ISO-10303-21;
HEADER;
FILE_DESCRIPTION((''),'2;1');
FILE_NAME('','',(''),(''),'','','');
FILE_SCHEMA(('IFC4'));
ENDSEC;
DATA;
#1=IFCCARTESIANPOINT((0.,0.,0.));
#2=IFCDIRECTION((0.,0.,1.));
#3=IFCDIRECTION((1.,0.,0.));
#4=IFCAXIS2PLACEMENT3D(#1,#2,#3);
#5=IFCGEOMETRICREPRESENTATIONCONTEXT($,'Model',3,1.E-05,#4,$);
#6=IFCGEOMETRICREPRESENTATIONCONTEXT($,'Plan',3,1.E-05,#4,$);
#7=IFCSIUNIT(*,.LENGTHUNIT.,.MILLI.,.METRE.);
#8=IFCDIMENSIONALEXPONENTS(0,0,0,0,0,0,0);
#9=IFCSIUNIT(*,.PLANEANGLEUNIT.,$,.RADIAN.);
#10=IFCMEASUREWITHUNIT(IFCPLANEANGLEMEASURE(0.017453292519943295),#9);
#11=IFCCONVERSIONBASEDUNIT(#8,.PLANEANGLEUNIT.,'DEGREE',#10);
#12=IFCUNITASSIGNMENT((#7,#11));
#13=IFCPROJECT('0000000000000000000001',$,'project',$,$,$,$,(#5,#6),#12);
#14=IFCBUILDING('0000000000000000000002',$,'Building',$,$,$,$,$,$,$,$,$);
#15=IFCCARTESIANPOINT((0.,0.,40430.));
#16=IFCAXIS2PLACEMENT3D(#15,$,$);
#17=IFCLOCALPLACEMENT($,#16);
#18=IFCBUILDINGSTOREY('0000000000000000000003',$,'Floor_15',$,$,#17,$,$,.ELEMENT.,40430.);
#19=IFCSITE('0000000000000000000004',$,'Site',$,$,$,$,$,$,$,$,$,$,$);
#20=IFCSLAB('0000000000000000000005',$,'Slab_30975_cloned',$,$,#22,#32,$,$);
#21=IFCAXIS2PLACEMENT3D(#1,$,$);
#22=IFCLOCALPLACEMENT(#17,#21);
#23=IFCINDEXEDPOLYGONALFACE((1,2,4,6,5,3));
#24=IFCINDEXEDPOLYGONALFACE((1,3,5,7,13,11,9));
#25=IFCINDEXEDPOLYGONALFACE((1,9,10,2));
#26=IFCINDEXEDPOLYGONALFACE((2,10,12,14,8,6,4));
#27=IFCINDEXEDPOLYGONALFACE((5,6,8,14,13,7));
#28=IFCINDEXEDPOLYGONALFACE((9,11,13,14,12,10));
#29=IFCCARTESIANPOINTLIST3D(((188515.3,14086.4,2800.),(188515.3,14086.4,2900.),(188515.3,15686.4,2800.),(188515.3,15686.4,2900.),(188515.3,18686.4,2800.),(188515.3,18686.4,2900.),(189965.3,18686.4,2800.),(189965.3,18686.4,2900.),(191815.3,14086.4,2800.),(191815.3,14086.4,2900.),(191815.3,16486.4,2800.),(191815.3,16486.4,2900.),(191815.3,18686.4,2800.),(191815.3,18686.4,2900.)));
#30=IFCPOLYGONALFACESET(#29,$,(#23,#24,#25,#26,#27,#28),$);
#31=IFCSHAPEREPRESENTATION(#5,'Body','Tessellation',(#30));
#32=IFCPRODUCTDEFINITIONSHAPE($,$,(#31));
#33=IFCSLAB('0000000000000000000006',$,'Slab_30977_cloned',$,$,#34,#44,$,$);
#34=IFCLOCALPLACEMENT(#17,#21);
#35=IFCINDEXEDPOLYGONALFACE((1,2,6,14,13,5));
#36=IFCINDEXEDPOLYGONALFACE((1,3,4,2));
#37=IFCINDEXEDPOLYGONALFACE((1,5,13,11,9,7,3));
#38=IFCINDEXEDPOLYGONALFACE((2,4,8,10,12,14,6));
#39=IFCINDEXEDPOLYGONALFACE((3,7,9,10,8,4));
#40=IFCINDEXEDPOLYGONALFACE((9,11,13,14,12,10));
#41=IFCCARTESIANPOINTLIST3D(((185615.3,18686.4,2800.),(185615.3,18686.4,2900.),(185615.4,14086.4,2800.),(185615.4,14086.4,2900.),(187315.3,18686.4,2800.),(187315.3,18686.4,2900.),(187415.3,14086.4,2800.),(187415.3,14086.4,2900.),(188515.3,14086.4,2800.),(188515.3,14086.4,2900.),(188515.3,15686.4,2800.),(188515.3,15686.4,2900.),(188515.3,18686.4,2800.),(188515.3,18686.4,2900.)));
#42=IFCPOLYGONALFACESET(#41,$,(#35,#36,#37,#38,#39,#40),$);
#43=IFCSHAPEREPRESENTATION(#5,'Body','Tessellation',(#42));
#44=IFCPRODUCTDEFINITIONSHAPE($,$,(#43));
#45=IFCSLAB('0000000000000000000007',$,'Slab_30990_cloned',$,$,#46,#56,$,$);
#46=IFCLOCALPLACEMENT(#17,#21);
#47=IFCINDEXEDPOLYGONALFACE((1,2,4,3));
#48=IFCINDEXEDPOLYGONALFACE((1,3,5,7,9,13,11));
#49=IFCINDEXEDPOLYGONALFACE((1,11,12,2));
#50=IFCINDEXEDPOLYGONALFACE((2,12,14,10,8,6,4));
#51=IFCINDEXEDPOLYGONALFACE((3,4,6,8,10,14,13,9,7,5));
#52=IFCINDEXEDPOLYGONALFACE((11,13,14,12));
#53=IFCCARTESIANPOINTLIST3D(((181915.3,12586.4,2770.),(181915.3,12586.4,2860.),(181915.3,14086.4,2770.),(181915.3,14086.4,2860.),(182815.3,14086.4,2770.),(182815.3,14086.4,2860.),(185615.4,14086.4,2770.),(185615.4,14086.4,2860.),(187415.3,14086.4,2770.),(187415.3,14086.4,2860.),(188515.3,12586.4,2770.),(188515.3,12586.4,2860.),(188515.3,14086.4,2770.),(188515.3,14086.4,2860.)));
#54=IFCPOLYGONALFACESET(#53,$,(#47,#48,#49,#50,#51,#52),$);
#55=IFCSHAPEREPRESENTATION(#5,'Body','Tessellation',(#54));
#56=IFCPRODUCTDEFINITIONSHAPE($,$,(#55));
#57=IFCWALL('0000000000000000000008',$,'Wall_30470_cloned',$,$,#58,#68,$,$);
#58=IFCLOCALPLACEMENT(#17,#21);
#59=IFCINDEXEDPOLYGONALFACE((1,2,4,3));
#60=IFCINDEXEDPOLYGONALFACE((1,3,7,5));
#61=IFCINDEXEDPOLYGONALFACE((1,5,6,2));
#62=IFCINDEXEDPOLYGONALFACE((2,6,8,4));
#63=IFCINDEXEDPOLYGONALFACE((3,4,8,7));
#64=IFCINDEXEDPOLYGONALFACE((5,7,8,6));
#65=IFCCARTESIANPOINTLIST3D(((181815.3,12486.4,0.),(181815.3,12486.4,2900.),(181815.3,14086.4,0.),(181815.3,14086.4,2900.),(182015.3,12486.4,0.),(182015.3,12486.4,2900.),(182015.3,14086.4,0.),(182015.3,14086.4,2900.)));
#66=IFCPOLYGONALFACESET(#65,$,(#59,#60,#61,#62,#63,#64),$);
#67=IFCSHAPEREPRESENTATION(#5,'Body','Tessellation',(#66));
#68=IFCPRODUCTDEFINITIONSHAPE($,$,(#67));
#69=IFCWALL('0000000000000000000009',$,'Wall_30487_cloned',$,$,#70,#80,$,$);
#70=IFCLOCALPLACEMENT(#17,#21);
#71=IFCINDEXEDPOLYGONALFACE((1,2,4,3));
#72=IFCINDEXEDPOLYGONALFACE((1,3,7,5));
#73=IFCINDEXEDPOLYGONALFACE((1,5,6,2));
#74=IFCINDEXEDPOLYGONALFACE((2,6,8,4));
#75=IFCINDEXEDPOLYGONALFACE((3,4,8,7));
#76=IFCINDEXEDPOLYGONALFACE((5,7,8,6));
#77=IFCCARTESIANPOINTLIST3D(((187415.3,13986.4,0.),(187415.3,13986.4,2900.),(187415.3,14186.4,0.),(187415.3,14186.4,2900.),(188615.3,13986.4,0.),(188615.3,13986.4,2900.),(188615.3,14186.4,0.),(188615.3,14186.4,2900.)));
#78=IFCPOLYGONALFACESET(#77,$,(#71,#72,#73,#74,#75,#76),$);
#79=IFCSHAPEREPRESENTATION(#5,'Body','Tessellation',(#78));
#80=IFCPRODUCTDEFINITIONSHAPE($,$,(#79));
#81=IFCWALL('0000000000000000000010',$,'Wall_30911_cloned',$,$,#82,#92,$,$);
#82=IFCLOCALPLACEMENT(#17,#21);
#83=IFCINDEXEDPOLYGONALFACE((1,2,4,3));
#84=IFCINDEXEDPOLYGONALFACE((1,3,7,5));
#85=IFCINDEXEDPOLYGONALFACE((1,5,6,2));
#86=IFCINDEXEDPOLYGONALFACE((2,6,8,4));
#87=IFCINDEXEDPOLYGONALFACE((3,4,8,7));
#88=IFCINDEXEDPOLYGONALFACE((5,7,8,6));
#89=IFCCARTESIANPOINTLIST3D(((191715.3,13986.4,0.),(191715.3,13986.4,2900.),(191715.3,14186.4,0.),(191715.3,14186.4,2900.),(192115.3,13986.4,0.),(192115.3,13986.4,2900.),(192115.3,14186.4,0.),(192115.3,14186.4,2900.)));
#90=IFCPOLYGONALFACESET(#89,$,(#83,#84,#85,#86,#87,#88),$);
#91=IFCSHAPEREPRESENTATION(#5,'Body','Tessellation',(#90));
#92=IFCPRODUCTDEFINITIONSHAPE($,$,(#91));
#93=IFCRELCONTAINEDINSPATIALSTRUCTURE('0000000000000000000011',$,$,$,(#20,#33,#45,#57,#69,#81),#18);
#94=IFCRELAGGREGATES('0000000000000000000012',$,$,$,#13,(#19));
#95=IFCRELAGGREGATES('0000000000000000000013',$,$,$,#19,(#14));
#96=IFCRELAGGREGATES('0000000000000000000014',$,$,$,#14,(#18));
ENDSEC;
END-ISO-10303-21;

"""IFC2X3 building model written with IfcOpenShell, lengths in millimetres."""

from ifc_helpers import new_model, entity, si_unit, converted_unit, frame, origin_with_axes, origin_2d, place, context, project, spatial, polyline, rectangle, outline, extrude, source, transform, mapped, element, save


model = new_model("IFC2X3")

# Units and contexts
model_context = context("Model", 3, precision=1e-05, world=origin_with_axes())
plan_context = context("Plan", 3, precision=1e-05, world=origin_with_axes())
ifc_project = project(units=[si_unit("LENGTHUNIT", "METRE", prefix="MILLI"), converted_unit("PLANEANGLEUNIT", "DEGREE", entity("IfcPlaneAngleMeasure", 0.017453292519943295), si_unit("PLANEANGLEUNIT", "RADIAN"), dimensions=[0, 0, 0, 0, 0, 0, 0])], contexts=[model_context, plan_context])

# Site, building, storey
site = spatial("IfcSite", under=ifc_project, Name="Site")
building = spatial("IfcBuilding", under=site, Name="Building")
storey_placement = place(None, frame((0.0, 0.0, 40430.0)))
storey = spatial("IfcBuildingStorey", under=building, at=storey_placement, Name="Floor_15", CompositionType="ELEMENT", Elevation=40430.0)

# Slabs
shared_shape_1 = source(origin_with_axes(), model_context, "Body", "SweptSolid", [
    extrude(outline(polyline([(0.0, 0.0), (3000.0, 0.0), (4600.0, 0.0), (4600.0, 3300.0), (2200.0, 3300.0), (0.0, 3300.0), (0.0, 1450.0)])), origin_with_axes(), (0.0, 0.0, 1.0), 100.0),
])
slab_1_placement = place(storey_placement, frame((188515.3, 18686.4, 2800.0), z_axis=(0.0, 0.0, 1.0), x_axis=(-0.027, -2999.994, 0.0)))
element("IfcSlab", 1, at=slab_1_placement, inside=storey, Name="Slab_30975_cloned", context=model_context, shape_type="MappedRepresentation", body=[
    mapped(shared_shape_1, transform((0.0, 0.0, 0.0), x_axis=(1.0, 0.0, 0.0), y_axis=(0.0, 1.0, 0.0), z_axis=(0.0, 0.0, 1.0), scale=1.0)),
])
shared_shape_2 = source(origin_with_axes(), model_context, "Body", "SweptSolid", [
    extrude(outline(polyline([(0.0, 0.0), (4600.0, 0.0), (4600.0, 1799.9), (4600.0, 2900.0), (3000.0, 2900.0), (0.0, 2900.0), (0.0, 1700.0)])), origin_with_axes(), (0.0, 0.0, 1.0), 100.0),
])
slab_2_placement = place(storey_placement, frame((185615.3, 18686.4, 2800.0), z_axis=(0.0, 0.0, 1.0), x_axis=(0.055, -4600.0, 0.0)))
element("IfcSlab", 2, at=slab_2_placement, inside=storey, Name="Slab_30977_cloned", context=model_context, shape_type="MappedRepresentation", body=[
    mapped(shared_shape_2, transform((0.0, 0.0, 0.0), x_axis=(1.0, 0.0, 0.0), y_axis=(0.0, 1.0, 0.0), z_axis=(0.0, 0.0, 1.0), scale=1.0)),
])
shared_shape_3 = source(origin_with_axes(), model_context, "Body", "SweptSolid", [
    extrude(outline(polyline([(0.0, 0.0), (1500.0, 0.0), (1500.0, 6600.0), (0.0, 6600.0), (0.0, 5500.0), (0.0, 3700.1), (0.0, 900.0)])), origin_with_axes(), (0.0, 0.0, 1.0), 90.0),
])
slab_3_placement = place(storey_placement, frame((181915.3, 14086.4, 2770.0), z_axis=(0.0, 0.0, 1.0), x_axis=(0.0, -1500.0, 0.0)))
element("IfcSlab", 3, at=slab_3_placement, inside=storey, Name="Slab_30990_cloned", context=model_context, shape_type="MappedRepresentation", body=[
    mapped(shared_shape_3, transform((0.0, 0.0, 0.0), x_axis=(1.0, 0.0, 0.0), y_axis=(0.0, 1.0, 0.0), z_axis=(0.0, 0.0, 1.0), scale=1.0)),
])

# Walls
shared_shape_4 = source(origin_with_axes(), model_context, "Body", "SweptSolid", [
    extrude(rectangle(XDim=1600.0, YDim=200.0, at=origin_2d()), origin_with_axes(), (0.0, 0.0, 1.0), 2900.0),
])
wall_1_placement = place(storey_placement, frame((181915.3, 13286.4, 0.0), z_axis=(0.0, 0.0, 1.0), x_axis=(0.0, 1600.000004, 0.0)))
element("IfcWall", 4, at=wall_1_placement, inside=storey, Name="Wall_30470_cloned", context=model_context, shape_type="MappedRepresentation", body=[
    mapped(shared_shape_4, transform((0.0, 0.0, 0.0), x_axis=(1.0, 0.0, 0.0), y_axis=(0.0, 1.0, 0.0), z_axis=(0.0, 0.0, 1.0), scale=1.0)),
])
shared_shape_5 = source(origin_with_axes(), model_context, "Body", "SweptSolid", [
    extrude(rectangle(XDim=1200.0, YDim=200.0, at=origin_2d()), origin_with_axes(), (0.0, 0.0, 1.0), 2900.0),
])
wall_2_placement = place(storey_placement, frame((188015.3, 14086.4, 0.0), z_axis=(0.0, 0.0, 1.0), x_axis=(1200.020798, 0.0, 0.0)))
element("IfcWall", 5, at=wall_2_placement, inside=storey, Name="Wall_30487_cloned", context=model_context, shape_type="MappedRepresentation", body=[
    mapped(shared_shape_5, transform((0.0, 0.0, 0.0), x_axis=(1.0, 0.0, 0.0), y_axis=(0.0, 1.0, 0.0), z_axis=(0.0, 0.0, 1.0), scale=1.0)),
])
shared_shape_6 = source(origin_with_axes(), model_context, "Body", "SweptSolid", [
    extrude(rectangle(XDim=400.0, YDim=200.0, at=origin_2d()), origin_with_axes(), (0.0, 0.0, 1.0), 2900.0),
])
wall_3_placement = place(storey_placement, frame((191915.3, 14086.4, 0.0), z_axis=(0.0, 0.0, 1.0), x_axis=(400.0, 0.0, 0.0)))
element("IfcWall", 6, at=wall_3_placement, inside=storey, Name="Wall_30911_cloned", context=model_context, shape_type="MappedRepresentation", body=[
    mapped(shared_shape_6, transform((0.0, 0.0, 0.0), x_axis=(1.0, 0.0, 0.0), y_axis=(0.0, 1.0, 0.0), z_axis=(0.0, 0.0, 1.0), scale=1.0)),
])

save(model, "model.ifc")
